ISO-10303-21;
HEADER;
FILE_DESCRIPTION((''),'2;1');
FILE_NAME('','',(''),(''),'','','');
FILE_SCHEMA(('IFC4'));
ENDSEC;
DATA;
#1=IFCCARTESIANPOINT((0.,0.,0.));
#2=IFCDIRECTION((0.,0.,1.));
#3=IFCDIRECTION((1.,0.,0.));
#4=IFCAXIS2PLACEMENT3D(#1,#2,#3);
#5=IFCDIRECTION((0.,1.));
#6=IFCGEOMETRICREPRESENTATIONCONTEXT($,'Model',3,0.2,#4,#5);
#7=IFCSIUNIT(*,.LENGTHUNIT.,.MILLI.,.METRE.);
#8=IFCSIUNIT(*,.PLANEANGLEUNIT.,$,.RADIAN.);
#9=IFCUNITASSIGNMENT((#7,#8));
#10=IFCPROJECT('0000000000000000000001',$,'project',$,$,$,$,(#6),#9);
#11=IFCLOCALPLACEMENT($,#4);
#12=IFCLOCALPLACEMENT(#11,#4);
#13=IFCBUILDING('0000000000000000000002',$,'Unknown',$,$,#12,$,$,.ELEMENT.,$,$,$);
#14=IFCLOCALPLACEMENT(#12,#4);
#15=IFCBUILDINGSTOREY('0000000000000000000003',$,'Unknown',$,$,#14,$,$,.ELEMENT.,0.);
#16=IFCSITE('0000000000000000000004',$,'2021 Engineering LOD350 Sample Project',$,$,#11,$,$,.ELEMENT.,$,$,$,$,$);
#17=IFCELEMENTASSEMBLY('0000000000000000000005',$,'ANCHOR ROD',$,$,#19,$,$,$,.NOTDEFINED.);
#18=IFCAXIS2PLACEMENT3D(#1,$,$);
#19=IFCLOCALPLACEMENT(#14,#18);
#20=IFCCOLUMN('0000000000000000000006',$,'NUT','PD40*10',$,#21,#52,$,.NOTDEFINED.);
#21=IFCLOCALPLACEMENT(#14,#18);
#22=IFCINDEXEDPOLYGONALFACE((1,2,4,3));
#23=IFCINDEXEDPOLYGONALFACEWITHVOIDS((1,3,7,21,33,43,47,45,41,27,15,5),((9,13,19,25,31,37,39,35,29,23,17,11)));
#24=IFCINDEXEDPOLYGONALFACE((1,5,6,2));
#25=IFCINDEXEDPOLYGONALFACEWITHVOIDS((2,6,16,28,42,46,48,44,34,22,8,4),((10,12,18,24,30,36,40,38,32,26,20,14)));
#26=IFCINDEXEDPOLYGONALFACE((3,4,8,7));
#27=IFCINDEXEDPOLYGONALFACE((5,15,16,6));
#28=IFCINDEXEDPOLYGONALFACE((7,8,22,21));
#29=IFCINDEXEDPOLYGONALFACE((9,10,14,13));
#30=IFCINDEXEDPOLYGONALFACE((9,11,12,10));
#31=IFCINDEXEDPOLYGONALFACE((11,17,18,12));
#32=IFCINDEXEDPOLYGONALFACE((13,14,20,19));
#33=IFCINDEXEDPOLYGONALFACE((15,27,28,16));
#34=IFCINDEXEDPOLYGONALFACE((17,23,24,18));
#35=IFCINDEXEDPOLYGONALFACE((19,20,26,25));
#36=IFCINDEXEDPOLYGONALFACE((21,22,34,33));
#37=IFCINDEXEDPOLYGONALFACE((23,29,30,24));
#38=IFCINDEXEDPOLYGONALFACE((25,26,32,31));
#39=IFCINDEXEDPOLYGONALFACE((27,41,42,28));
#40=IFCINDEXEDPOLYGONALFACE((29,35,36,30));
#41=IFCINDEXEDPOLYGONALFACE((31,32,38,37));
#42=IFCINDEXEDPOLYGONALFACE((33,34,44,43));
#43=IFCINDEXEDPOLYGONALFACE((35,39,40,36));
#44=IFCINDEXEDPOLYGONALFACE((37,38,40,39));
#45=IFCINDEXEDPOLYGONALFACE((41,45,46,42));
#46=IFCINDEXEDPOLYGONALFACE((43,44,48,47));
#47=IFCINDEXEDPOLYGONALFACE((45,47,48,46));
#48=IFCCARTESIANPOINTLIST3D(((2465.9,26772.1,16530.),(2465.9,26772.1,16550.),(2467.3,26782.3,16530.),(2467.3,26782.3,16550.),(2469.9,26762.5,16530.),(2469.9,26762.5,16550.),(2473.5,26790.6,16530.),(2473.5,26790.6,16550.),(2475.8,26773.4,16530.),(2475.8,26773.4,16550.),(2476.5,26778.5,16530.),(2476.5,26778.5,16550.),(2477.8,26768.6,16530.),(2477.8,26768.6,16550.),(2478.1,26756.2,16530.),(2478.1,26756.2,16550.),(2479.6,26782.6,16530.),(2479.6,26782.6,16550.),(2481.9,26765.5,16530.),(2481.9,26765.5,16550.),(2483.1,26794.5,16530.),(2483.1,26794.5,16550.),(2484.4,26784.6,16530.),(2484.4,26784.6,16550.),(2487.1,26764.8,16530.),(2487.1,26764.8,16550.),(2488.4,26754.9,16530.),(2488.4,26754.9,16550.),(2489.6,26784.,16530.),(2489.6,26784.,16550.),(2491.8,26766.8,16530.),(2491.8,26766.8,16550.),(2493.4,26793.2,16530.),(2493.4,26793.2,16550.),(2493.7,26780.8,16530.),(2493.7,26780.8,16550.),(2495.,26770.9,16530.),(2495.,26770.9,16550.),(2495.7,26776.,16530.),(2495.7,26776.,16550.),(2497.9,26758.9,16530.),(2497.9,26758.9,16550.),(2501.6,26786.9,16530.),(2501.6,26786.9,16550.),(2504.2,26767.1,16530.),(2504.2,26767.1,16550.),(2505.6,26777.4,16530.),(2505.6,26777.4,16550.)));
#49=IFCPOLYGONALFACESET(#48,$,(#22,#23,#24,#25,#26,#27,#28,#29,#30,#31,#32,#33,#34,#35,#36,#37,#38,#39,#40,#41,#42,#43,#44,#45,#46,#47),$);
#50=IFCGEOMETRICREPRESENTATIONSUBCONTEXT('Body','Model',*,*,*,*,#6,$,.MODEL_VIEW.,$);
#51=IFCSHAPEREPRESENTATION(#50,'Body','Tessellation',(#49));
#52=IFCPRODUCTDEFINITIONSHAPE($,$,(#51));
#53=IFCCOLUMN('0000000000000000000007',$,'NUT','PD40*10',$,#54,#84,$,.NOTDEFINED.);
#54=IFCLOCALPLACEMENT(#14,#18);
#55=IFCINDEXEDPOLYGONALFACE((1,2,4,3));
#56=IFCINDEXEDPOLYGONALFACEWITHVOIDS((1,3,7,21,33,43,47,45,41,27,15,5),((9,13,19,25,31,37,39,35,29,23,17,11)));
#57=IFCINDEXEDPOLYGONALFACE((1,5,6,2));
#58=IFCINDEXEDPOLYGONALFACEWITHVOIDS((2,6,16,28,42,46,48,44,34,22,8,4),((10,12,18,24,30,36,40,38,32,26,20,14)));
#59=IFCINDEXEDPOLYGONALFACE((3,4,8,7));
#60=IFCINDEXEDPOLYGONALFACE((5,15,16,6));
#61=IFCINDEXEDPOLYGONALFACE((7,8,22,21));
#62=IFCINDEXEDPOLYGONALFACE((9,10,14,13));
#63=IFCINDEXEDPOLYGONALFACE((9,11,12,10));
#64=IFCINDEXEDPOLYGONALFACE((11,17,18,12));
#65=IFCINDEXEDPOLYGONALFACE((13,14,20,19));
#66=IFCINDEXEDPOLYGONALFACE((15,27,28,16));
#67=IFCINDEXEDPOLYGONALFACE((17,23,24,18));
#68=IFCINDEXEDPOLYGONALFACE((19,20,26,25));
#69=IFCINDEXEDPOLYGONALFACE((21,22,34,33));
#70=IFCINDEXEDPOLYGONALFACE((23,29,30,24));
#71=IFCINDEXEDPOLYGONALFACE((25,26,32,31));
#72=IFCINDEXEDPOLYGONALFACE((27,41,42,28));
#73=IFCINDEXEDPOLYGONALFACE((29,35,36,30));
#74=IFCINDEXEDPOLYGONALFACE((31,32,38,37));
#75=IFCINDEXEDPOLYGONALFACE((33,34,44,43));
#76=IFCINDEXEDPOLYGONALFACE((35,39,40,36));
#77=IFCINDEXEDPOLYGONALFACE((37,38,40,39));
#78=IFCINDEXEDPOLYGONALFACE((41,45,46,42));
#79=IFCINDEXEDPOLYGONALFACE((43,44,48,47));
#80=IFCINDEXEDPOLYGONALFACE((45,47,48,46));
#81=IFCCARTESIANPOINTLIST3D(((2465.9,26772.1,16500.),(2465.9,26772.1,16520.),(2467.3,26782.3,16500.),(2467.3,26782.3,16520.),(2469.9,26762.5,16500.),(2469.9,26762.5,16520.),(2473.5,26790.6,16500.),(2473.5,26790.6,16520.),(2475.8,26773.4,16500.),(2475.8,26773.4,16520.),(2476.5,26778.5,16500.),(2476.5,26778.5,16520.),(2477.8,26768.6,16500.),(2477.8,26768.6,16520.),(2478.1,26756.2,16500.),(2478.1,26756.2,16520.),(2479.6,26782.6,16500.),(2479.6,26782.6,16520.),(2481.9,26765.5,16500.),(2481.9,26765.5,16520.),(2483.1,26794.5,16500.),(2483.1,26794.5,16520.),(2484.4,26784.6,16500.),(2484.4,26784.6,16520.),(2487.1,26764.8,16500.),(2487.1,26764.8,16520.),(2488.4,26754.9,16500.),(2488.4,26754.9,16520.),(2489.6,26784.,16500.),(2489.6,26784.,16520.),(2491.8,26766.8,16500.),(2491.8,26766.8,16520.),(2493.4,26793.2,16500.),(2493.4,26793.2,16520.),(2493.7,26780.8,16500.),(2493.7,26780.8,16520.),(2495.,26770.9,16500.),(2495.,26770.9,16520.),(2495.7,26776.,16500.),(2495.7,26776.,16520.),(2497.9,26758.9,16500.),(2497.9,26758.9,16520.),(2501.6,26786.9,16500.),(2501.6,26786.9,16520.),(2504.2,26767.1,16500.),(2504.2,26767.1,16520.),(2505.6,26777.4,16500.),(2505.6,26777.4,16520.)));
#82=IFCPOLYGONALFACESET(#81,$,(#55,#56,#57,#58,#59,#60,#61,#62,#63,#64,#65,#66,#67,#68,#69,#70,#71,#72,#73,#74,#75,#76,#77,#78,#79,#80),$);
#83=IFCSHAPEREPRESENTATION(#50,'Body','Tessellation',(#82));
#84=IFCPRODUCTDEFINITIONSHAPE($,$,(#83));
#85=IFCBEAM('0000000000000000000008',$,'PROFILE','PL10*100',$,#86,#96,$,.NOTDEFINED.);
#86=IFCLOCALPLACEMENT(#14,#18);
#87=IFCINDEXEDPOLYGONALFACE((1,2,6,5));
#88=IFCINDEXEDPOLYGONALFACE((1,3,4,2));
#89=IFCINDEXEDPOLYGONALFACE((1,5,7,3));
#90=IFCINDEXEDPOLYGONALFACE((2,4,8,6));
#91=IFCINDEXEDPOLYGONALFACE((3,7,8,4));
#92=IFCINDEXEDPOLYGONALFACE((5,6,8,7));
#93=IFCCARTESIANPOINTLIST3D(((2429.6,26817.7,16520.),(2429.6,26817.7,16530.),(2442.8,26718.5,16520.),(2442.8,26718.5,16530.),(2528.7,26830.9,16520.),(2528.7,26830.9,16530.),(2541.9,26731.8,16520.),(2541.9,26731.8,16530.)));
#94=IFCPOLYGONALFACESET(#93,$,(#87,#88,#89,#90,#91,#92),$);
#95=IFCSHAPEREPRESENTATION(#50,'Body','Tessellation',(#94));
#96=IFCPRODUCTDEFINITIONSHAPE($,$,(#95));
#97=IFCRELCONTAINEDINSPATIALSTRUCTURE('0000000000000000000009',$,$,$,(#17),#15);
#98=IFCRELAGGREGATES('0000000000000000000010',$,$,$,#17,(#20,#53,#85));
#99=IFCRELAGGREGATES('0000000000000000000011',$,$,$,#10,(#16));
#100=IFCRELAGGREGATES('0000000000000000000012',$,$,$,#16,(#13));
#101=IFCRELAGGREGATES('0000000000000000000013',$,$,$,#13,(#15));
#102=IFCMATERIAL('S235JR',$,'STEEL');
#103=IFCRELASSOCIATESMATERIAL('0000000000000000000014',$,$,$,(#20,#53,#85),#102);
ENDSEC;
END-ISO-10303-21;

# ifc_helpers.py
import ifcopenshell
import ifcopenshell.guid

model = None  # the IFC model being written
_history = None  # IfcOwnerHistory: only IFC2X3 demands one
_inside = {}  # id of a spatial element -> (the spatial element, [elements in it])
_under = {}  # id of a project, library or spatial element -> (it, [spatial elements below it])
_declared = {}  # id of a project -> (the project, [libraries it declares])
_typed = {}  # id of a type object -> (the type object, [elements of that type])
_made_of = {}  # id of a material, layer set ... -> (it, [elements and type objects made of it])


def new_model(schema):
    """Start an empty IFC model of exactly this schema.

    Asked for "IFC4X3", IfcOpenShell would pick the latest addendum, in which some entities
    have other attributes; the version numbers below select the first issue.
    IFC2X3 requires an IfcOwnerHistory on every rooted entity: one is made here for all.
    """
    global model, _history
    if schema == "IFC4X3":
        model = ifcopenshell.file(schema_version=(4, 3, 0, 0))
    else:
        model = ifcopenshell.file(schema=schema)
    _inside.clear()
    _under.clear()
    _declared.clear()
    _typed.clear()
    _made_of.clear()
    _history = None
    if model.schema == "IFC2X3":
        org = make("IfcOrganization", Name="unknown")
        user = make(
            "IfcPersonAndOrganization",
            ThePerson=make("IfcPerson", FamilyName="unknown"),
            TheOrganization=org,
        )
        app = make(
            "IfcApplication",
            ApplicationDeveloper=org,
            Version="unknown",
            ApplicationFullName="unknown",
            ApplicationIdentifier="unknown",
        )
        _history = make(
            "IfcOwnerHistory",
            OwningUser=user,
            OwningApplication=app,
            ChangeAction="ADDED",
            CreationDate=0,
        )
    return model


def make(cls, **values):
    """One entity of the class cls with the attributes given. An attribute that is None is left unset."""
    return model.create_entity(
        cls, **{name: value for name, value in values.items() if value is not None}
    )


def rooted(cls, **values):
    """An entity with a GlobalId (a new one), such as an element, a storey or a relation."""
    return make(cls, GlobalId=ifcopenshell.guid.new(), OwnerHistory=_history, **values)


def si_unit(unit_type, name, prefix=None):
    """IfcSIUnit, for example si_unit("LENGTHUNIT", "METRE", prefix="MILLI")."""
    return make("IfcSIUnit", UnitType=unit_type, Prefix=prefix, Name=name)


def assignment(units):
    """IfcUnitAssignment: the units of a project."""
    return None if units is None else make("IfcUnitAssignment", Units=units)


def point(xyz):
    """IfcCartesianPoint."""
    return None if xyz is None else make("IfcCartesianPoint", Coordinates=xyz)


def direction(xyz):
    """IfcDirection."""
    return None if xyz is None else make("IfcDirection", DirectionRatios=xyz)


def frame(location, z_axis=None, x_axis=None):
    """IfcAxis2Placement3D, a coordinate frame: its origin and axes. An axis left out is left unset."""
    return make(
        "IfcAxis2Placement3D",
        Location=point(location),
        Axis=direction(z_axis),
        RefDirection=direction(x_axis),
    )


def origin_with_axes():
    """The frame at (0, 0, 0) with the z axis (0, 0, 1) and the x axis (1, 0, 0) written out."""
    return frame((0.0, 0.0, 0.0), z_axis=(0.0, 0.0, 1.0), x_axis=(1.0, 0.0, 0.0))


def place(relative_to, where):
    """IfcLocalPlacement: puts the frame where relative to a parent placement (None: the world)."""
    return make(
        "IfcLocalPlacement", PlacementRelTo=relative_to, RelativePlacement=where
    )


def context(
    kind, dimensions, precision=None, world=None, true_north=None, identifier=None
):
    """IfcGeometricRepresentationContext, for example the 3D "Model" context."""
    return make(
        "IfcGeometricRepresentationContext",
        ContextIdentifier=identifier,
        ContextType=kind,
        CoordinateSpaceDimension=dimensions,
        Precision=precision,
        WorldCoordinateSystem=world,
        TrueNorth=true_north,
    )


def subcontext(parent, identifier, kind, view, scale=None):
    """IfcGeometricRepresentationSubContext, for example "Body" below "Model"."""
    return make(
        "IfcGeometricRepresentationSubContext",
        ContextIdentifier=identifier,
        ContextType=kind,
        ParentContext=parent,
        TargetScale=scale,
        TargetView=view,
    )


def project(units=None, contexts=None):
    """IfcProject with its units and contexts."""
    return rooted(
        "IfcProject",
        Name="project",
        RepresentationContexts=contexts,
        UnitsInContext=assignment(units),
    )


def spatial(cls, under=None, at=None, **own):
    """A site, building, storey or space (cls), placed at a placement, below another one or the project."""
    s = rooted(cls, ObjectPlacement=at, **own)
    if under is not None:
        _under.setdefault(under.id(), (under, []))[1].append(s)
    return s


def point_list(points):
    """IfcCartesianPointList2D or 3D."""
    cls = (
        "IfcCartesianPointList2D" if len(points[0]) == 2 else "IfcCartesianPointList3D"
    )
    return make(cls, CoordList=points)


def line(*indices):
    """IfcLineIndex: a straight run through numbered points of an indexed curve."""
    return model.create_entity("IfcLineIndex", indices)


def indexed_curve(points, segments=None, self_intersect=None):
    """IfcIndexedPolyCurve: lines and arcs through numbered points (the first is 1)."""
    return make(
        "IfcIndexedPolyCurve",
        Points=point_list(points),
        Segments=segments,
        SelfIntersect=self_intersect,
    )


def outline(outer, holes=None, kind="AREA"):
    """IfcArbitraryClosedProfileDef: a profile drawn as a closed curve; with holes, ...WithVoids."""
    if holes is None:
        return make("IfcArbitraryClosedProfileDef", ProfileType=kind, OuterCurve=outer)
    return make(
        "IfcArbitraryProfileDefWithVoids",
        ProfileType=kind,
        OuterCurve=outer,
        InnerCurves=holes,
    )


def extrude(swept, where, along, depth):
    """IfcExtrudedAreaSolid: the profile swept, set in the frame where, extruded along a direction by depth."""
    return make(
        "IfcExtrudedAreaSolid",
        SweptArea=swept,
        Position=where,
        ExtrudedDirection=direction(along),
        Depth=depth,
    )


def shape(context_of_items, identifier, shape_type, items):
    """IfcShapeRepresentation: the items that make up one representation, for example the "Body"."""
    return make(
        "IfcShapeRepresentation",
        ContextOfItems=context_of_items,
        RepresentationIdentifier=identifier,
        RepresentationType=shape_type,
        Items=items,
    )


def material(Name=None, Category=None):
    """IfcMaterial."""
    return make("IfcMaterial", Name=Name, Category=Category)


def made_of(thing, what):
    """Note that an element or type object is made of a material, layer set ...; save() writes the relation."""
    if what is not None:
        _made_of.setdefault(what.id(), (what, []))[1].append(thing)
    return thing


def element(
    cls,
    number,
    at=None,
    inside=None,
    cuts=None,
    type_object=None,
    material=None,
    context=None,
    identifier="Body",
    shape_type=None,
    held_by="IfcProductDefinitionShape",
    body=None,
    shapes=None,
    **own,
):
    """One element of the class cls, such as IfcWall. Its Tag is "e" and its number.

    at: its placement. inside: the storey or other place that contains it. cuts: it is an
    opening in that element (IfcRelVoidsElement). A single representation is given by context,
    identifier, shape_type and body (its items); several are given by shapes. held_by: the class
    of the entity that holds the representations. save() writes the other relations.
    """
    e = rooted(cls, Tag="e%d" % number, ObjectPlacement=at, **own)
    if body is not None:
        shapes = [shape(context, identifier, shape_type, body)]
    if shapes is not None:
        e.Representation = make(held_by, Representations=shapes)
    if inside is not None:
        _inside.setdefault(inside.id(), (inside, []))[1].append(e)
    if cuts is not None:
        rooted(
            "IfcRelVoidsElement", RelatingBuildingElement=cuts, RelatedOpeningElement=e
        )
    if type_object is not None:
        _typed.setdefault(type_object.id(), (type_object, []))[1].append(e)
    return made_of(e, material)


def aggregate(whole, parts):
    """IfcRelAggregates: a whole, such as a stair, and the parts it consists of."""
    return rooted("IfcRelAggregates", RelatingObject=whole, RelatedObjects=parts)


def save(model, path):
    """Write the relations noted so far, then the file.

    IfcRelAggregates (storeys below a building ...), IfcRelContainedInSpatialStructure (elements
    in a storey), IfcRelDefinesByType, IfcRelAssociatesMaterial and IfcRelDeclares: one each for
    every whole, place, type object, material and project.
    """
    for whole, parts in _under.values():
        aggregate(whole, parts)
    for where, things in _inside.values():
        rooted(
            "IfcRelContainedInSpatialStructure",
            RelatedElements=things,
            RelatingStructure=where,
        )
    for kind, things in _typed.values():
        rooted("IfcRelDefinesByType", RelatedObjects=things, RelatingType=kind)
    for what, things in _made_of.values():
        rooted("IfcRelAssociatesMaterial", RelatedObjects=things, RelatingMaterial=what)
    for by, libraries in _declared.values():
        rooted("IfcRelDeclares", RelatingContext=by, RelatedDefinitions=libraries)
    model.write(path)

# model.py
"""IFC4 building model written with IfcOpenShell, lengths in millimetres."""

from ifc_helpers import new_model, si_unit, direction, frame, origin_with_axes, place, context, subcontext, project, spatial, line, indexed_curve, outline, extrude, material, element, aggregate, save


model = new_model("IFC4")

# Units and contexts
model_context = context("Model", 3, precision=0.2, world=origin_with_axes(), true_north=direction((0.0, 1.0)))
body_context = subcontext(model_context, "Body", "Model", "MODEL_VIEW")
ifc_project = project(units=[si_unit("LENGTHUNIT", "METRE", prefix="MILLI"), si_unit("PLANEANGLEUNIT", "RADIAN")], contexts=[model_context])

# Site, building, storey
site_placement = place(None, origin_with_axes())
site = spatial("IfcSite", under=ifc_project, at=site_placement, Name="2021 Engineering LOD350 Sample Project", CompositionType="ELEMENT")
building_placement = place(site_placement, origin_with_axes())
building = spatial("IfcBuilding", under=site, at=building_placement, Name="Unknown", CompositionType="ELEMENT")
storey_placement = place(building_placement, origin_with_axes())
storey = spatial("IfcBuildingStorey", under=building, at=storey_placement, Name="Unknown", CompositionType="ELEMENT", Elevation=0.0)

# Element assembly, columns, beam
assembly_1_placement = place(storey_placement, frame((2485.7, 26774.7, 16730.0), z_axis=(0.991216, 0.132256, 0.0), x_axis=(0.0, 0.0, -1.0)))
assembly_1 = element("IfcElementAssembly", 1, at=assembly_1_placement, inside=storey, Name="ANCHOR ROD", PredefinedType="NOTDEFINED")
ifc_material_1 = material(Name="S235JR", Category="STEEL")
column_1_placement = place(assembly_1_placement, frame((180.0, 0.0, 0.0), z_axis=(0.0, 0.0, 1.0), x_axis=(1.0, 0.0, 0.0)))
column_1 = element("IfcColumn", 2, at=column_1_placement, material=ifc_material_1, Name="NUT", Description="PD40*10", PredefinedType="NOTDEFINED", context=body_context, shape_type="SolidModel", body=[
    extrude(outline(indexed_curve([(20.0, 0.0), (17.3, 10.0), (10.0, 17.3), (0.0, 20.0), (-10.0, 17.3), (-17.3, 10.0), (-20.0, 0.0), (-17.3, -10.0), (-10.0, -17.3), (0.0, -20.0), (10.0, -17.3), (17.3, -10.0)], segments=[line(1, 2, 3, 4, 5, 6, 7, 8, 9, 10, 11, 12, 1)]), holes=[indexed_curve([(10.0, 0.0), (8.7, -5.0), (5.0, -8.7), (0.0, -10.0), (-5.0, -8.7), (-8.7, -5.0), (-10.0, 0.0), (-8.7, 5.0), (-5.0, 8.7), (0.0, 10.0), (5.0, 8.7), (8.7, 5.0)], segments=[line(1, 2, 3, 4, 5, 6, 7, 8, 9, 10, 11, 12, 1)])]), frame((0.0, 0.0, 0.0), z_axis=(-1.0, 0.0, 0.0), x_axis=(0.0, 0.0, 1.0)), (0.0, 0.0, -1.0), 20.0),
])
column_2_placement = place(assembly_1_placement, frame((210.0, 0.0, 0.0), z_axis=(0.0, 0.0, 1.0), x_axis=(1.0, 0.0, 0.0)))
column_2 = element("IfcColumn", 3, at=column_2_placement, material=ifc_material_1, Name="NUT", Description="PD40*10", PredefinedType="NOTDEFINED", context=body_context, shape_type="SolidModel", body=[
    extrude(outline(indexed_curve([(20.0, 0.0), (17.3, 10.0), (10.0, 17.3), (0.0, 20.0), (-10.0, 17.3), (-17.3, 10.0), (-20.0, 0.0), (-17.3, -10.0), (-10.0, -17.3), (0.0, -20.0), (10.0, -17.3), (17.3, -10.0)], segments=[line(1, 2, 3, 4, 5, 6, 7, 8, 9, 10, 11, 12, 1)]), holes=[indexed_curve([(10.0, 0.0), (8.7, -5.0), (5.0, -8.7), (0.0, -10.0), (-5.0, -8.7), (-8.7, -5.0), (-10.0, 0.0), (-8.7, 5.0), (-5.0, 8.7), (0.0, 10.0), (5.0, 8.7), (8.7, 5.0)], segments=[line(1, 2, 3, 4, 5, 6, 7, 8, 9, 10, 11, 12, 1)])]), frame((0.0, 0.0, 0.0), z_axis=(-1.0, 0.0, 0.0), x_axis=(0.0, 0.0, 1.0)), (0.0, 0.0, -1.0), 20.0),
])
beam_1_placement = place(assembly_1_placement, frame((205.0, -50.0, 0.0), z_axis=(1.0, 0.0, 0.0), x_axis=(0.0, 1.0, 0.0)))
beam_1 = element("IfcBeam", 4, at=beam_1_placement, material=ifc_material_1, Name="PROFILE", Description="PL10*100", PredefinedType="NOTDEFINED", context=body_context, shape_type="SolidModel", body=[
    extrude(outline(indexed_curve([(-5.0, -50.0), (5.0, -50.0), (5.0, 50.0), (-5.0, 50.0)], segments=[line(1, 2, 3, 4, 1)])), frame((0.0, 0.0, 0.0), z_axis=(-1.0, 0.0, 0.0), x_axis=(0.0, 0.0, 1.0)), (0.0, 0.0, -1.0), 100.0),
])

aggregate(assembly_1, [column_1, column_2, beam_1])

save(model, "model.ifc")
